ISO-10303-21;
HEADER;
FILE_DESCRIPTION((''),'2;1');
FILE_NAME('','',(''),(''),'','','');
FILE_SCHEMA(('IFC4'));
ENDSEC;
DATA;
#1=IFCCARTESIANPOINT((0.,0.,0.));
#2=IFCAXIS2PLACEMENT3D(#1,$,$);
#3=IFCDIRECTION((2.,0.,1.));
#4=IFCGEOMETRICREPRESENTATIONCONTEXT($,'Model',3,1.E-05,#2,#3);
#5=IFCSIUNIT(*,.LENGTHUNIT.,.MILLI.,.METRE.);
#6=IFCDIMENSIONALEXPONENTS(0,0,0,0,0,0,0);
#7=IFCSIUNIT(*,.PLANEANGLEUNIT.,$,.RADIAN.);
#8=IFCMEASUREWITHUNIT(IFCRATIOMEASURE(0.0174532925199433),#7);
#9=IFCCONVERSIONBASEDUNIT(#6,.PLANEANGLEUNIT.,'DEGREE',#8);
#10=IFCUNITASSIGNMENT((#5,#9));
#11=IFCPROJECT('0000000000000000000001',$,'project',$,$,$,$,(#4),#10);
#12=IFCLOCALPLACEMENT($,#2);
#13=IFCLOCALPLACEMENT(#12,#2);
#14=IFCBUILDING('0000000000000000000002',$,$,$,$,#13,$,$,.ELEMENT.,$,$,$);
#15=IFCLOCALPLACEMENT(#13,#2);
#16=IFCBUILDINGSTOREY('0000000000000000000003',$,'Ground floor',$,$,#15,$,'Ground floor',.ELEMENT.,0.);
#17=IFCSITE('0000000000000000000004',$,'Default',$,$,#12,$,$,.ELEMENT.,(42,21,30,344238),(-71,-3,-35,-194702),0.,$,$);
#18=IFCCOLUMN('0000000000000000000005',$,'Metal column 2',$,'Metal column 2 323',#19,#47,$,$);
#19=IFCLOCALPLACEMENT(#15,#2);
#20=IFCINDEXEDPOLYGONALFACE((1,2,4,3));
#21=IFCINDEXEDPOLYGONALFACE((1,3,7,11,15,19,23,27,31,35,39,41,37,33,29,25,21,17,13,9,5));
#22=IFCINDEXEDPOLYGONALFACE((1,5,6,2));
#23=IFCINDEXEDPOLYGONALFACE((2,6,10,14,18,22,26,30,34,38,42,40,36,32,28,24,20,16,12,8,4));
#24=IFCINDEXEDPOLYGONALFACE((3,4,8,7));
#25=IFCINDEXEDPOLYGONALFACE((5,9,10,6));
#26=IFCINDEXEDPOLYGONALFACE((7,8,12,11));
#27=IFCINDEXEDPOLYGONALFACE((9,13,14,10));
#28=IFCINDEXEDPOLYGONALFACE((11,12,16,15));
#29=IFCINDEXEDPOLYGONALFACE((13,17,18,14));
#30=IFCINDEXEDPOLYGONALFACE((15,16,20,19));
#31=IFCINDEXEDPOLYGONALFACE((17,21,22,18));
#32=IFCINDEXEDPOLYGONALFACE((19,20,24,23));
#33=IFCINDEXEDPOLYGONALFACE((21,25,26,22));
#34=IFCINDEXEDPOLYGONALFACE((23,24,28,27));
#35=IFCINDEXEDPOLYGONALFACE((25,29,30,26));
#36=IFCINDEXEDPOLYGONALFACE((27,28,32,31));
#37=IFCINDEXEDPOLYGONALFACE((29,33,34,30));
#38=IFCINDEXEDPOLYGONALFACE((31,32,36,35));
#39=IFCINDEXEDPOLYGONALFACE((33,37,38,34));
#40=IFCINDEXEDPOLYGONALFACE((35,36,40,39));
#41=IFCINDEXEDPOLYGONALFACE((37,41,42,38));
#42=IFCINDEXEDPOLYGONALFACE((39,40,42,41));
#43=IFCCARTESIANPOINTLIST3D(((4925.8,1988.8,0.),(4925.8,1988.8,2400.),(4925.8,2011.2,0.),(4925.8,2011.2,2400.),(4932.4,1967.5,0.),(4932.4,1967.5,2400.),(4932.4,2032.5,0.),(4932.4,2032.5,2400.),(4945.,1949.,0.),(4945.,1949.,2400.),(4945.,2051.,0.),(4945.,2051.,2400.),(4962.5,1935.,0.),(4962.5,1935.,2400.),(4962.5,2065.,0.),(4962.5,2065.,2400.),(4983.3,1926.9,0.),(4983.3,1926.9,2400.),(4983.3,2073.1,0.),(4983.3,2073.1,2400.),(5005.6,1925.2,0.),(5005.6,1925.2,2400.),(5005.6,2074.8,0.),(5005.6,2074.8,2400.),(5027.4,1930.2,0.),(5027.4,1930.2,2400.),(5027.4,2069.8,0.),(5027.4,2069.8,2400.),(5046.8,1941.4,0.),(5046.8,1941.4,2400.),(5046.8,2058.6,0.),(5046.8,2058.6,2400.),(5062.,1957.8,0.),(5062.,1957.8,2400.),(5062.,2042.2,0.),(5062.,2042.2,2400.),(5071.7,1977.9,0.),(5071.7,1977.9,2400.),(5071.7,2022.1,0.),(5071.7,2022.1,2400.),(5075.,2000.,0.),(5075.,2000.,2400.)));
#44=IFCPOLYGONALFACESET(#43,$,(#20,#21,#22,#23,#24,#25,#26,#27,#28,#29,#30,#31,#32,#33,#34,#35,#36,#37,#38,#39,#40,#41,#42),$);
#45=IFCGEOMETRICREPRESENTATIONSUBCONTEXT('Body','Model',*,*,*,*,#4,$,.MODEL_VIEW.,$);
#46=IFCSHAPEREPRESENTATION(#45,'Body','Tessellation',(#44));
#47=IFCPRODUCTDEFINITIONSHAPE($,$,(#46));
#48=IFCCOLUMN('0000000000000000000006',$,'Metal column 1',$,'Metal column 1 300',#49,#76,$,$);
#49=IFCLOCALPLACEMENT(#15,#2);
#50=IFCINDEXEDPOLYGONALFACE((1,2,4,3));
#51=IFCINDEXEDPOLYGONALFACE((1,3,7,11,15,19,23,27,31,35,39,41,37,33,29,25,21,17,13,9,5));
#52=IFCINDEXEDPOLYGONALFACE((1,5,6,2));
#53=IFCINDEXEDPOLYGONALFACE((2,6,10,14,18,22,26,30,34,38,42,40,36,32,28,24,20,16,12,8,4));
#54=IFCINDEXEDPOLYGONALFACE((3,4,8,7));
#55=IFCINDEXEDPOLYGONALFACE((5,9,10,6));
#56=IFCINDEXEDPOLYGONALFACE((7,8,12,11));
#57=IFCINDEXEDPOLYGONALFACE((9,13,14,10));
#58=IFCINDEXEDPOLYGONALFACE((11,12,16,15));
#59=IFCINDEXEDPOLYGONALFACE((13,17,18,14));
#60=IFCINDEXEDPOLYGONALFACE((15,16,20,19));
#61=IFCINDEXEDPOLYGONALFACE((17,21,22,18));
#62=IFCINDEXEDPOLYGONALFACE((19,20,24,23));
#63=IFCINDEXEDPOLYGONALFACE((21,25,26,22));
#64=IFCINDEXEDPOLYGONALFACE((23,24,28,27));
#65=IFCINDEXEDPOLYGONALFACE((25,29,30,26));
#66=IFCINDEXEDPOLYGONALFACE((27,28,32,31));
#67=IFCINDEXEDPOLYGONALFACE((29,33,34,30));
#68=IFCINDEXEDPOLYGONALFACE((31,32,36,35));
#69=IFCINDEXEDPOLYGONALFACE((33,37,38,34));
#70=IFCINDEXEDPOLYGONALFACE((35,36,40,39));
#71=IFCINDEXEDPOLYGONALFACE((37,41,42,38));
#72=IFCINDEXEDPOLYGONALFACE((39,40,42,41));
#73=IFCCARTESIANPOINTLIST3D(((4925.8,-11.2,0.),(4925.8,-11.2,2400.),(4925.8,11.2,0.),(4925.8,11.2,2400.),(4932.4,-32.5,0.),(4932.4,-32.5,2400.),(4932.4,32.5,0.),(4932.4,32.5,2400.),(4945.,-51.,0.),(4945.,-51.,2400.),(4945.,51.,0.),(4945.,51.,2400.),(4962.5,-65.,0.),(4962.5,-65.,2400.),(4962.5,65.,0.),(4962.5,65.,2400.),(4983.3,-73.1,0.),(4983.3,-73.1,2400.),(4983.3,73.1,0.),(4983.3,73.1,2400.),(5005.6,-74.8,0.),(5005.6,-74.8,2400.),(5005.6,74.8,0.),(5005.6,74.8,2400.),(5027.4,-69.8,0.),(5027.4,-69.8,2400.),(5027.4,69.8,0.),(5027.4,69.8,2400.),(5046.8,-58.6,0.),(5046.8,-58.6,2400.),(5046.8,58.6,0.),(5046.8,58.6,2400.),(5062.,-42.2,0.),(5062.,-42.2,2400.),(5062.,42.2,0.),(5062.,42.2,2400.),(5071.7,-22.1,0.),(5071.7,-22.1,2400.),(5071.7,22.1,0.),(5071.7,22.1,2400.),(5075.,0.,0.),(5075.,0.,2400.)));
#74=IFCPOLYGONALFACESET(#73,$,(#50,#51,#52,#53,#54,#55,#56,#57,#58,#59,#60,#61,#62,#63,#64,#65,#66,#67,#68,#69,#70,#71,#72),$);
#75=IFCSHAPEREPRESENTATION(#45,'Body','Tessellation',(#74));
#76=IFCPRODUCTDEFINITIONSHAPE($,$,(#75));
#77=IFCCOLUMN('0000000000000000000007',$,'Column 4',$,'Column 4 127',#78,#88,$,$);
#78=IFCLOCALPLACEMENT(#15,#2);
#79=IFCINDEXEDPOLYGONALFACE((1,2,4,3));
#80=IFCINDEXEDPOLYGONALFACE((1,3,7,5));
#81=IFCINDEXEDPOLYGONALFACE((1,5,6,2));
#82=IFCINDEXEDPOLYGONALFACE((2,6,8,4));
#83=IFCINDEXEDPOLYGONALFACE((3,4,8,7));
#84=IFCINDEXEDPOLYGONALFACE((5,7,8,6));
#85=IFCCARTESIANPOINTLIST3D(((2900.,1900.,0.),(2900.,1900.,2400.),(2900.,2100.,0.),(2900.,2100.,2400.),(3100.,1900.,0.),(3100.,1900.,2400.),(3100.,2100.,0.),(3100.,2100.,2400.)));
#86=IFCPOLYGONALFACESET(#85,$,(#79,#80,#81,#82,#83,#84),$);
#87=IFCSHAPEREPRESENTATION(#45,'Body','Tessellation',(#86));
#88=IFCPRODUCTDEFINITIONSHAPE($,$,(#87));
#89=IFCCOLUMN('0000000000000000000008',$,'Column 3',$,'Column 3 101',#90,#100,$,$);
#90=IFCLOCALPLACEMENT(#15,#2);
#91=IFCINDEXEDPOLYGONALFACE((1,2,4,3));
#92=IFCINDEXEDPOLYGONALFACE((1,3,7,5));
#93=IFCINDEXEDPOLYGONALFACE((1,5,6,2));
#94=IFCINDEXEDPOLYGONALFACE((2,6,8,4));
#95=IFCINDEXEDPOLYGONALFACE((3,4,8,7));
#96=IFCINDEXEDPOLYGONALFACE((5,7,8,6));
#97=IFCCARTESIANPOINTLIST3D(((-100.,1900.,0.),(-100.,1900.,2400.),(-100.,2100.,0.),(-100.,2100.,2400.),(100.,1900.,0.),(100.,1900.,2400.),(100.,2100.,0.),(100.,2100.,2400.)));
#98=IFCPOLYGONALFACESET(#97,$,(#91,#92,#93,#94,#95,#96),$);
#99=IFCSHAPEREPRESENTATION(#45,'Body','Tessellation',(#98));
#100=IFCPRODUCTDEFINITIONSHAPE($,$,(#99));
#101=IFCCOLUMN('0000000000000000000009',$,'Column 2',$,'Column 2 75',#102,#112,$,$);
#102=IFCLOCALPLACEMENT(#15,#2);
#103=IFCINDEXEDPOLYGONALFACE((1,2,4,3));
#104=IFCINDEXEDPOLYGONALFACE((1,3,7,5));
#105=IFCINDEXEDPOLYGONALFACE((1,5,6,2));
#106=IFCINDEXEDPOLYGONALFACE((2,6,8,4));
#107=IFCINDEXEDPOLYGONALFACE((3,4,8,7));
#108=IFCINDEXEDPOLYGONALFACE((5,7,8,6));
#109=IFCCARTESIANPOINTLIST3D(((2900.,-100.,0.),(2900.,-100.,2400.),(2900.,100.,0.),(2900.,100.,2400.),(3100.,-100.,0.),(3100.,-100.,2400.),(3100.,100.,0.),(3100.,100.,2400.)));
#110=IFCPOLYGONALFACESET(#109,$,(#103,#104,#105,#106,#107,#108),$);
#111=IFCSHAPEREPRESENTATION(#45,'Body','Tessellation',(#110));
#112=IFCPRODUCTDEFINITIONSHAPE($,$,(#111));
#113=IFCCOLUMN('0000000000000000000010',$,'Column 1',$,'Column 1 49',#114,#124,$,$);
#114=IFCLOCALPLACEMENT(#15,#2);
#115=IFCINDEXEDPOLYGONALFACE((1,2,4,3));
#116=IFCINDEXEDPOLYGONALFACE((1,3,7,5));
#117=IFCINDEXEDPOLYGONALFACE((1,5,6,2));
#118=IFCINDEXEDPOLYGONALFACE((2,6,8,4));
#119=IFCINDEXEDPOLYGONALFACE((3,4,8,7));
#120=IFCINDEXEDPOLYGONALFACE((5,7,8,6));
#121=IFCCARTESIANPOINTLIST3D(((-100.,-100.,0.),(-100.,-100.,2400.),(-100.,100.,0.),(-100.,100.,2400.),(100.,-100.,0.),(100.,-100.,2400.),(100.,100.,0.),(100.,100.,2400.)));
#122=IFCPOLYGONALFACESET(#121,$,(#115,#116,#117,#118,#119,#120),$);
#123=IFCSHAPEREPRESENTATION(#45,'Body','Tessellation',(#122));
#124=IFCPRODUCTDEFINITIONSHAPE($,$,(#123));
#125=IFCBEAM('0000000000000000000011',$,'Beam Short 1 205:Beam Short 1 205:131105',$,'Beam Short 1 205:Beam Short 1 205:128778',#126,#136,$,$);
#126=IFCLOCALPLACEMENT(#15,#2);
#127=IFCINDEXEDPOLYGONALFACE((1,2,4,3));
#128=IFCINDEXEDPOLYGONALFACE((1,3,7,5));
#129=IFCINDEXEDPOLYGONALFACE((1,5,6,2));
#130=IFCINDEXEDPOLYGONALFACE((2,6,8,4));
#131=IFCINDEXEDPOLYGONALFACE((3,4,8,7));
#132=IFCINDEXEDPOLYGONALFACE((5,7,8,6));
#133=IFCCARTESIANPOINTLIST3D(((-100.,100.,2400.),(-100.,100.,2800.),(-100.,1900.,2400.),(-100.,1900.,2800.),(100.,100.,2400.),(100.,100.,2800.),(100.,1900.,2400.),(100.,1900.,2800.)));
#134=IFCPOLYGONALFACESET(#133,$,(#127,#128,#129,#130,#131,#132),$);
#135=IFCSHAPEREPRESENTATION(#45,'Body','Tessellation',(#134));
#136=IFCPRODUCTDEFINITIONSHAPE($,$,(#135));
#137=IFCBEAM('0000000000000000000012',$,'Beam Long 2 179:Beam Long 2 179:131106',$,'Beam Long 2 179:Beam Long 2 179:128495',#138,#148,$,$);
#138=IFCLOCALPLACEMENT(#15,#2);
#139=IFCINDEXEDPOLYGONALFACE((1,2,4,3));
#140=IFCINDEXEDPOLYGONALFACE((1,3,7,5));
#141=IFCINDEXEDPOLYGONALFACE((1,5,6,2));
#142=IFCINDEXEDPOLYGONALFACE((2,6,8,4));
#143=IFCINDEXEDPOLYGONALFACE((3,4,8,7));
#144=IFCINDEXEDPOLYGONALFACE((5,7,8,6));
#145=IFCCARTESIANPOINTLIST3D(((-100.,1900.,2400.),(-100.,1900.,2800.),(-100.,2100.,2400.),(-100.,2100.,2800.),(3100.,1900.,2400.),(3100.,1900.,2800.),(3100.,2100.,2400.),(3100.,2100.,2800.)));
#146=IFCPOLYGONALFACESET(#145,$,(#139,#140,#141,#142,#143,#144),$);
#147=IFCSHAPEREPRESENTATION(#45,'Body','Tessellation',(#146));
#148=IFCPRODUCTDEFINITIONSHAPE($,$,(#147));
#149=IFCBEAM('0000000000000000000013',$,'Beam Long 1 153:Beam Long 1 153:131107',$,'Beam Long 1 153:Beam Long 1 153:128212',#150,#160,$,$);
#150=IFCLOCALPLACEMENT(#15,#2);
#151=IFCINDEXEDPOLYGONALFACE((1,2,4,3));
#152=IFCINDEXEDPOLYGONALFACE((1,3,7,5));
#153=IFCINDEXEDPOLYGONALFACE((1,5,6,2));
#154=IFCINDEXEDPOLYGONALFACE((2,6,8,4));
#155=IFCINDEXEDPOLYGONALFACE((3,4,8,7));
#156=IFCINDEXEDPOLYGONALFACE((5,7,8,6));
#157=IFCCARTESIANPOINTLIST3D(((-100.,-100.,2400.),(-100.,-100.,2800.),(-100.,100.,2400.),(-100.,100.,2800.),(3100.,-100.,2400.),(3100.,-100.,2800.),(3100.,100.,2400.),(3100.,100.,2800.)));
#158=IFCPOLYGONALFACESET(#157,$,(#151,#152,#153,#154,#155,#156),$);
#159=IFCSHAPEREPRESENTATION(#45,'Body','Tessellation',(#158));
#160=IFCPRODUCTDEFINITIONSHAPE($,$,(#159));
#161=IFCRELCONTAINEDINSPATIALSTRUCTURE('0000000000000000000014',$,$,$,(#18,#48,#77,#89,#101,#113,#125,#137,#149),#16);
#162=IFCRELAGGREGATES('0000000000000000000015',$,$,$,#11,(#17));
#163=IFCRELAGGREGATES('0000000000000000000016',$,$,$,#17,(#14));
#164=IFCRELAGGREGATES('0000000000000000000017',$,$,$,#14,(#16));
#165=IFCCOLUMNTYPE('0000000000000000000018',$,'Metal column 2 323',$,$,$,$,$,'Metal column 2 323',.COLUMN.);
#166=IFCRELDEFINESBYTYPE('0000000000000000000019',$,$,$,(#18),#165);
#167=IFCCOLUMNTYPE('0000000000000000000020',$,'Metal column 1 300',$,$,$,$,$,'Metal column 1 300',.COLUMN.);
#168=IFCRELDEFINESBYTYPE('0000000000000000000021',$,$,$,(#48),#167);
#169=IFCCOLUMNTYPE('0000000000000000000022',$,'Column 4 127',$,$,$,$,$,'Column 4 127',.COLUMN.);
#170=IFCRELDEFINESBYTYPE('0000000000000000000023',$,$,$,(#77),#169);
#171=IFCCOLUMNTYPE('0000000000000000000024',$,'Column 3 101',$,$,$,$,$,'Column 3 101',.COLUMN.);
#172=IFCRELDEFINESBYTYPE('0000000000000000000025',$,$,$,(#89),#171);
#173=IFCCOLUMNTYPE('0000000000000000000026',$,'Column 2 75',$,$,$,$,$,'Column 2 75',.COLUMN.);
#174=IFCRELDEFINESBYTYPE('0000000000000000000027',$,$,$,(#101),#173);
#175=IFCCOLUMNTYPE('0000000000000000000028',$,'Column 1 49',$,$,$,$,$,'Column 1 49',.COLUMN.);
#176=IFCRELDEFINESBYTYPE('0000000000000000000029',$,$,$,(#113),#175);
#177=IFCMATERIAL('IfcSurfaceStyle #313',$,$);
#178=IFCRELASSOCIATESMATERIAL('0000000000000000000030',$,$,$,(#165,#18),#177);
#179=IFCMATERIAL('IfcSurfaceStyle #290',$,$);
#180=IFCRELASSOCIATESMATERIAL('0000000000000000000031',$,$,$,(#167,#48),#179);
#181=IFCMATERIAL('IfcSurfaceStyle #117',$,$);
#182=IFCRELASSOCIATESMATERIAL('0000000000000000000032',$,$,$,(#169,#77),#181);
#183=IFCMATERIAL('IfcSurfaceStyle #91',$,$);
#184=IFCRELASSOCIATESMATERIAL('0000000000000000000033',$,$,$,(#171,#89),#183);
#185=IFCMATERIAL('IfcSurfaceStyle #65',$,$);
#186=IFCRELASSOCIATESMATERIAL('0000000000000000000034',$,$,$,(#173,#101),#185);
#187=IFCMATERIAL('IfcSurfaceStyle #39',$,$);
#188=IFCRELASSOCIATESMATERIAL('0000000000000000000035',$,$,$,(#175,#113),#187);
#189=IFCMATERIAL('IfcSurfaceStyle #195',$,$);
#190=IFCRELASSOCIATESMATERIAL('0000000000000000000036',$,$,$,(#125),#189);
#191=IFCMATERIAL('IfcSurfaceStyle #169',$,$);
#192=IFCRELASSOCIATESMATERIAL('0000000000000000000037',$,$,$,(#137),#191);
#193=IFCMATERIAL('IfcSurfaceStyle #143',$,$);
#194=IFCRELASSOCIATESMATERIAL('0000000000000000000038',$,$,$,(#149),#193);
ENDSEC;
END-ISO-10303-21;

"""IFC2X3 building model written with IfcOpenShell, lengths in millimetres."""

from ifc_helpers import new_model, entity, si_unit, converted_unit, direction, frame, frame_2d, origin, origin_2d_with_axis, place, context, subcontext, project, spatial, rectangle, circle, extrude, source, transform, mapped, material, type_object, type_shapes, element, save


model = new_model("IFC2X3")

# Units and contexts
model_context = context("Model", 3, precision=1e-05, world=origin(), true_north=direction((2.0, 0.0, 1.0)))
body_context = subcontext(model_context, "Body", "Model", "MODEL_VIEW")
ifc_project = project(units=[si_unit("LENGTHUNIT", "METRE", prefix="MILLI"), converted_unit("PLANEANGLEUNIT", "DEGREE", entity("IfcRatioMeasure", 0.0174532925199433), si_unit("PLANEANGLEUNIT", "RADIAN"), dimensions=[0, 0, 0, 0, 0, 0, 0])], contexts=[model_context])

# Site, building, storey
site_placement = place(None, origin())
site = spatial("IfcSite", under=ifc_project, at=site_placement, Name="Default", CompositionType="ELEMENT", RefLatitude=(42, 21, 30, 344238), RefLongitude=(-71, -3, -35, -194702), RefElevation=0.0)
building_placement = place(site_placement, origin())
building = spatial("IfcBuilding", under=site, at=building_placement, CompositionType="ELEMENT")
storey_placement = place(building_placement, origin())
storey = spatial("IfcBuildingStorey", under=building, at=storey_placement, Name="Ground floor", LongName="Ground floor", CompositionType="ELEMENT", Elevation=0.0)

# Columns
ifc_material_1 = material(Name="IfcSurfaceStyle #313")
column_type_1 = type_object("IfcColumnType", Name="Metal column 2 323", ElementType="Metal column 2 323", PredefinedType="COLUMN", material=ifc_material_1)
shared_shape_1 = source(origin(), body_context, "Body", "SweptSolid", [
    extrude(circle(Radius=75.0, at=frame_2d((0.0, 0.0), x_axis=(1.0, 0.0))), frame((5000.0, 2000.0, 0.0)), (0.0, 0.0, 1.0), 2400.0),
])
type_shapes(column_type_1, [shared_shape_1])
column_1_placement = place(building_placement, origin())
element("IfcColumn", 1, at=column_1_placement, inside=storey, type_object=column_type_1, material=ifc_material_1, Name="Metal column 2", ObjectType="Metal column 2 323", context=body_context, shape_type="MappedRepresentation", body=[
    mapped(shared_shape_1, transform((0.0, 0.0, 0.0), scale=1.0)),
])
ifc_material_2 = material(Name="IfcSurfaceStyle #290")
column_type_2 = type_object("IfcColumnType", Name="Metal column 1 300", ElementType="Metal column 1 300", PredefinedType="COLUMN", material=ifc_material_2)
shared_shape_2 = source(origin(), body_context, "Body", "SweptSolid", [
    extrude(circle(Radius=75.0, at=frame_2d((0.0, 0.0), x_axis=(1.0, 0.0))), frame((5000.0, 0.0, 0.0)), (0.0, 0.0, 1.0), 2400.0),
])
type_shapes(column_type_2, [shared_shape_2])
column_2_placement = place(building_placement, origin())
element("IfcColumn", 2, at=column_2_placement, inside=storey, type_object=column_type_2, material=ifc_material_2, Name="Metal column 1", ObjectType="Metal column 1 300", context=body_context, shape_type="MappedRepresentation", body=[
    mapped(shared_shape_2, transform((0.0, 0.0, 0.0), scale=1.0)),
])
ifc_material_3 = material(Name="IfcSurfaceStyle #117")
column_type_3 = type_object("IfcColumnType", Name="Column 4 127", ElementType="Column 4 127", PredefinedType="COLUMN", material=ifc_material_3)
shared_shape_3 = source(origin(), body_context, "Body", "SweptSolid", [
    extrude(rectangle(XDim=200.0, YDim=200.0, at=origin_2d_with_axis()), frame((3000.0, 2000.0, 0.0), z_axis=(0.0, 0.0, 1.0), x_axis=(0.0, -1.0, 0.0)), (0.0, 0.0, 1.0), 2400.0),
])
type_shapes(column_type_3, [shared_shape_3])
column_3_placement = place(building_placement, origin())
element("IfcColumn", 3, at=column_3_placement, inside=storey, type_object=column_type_3, material=ifc_material_3, Name="Column 4", ObjectType="Column 4 127", context=body_context, shape_type="MappedRepresentation", body=[
    mapped(shared_shape_3, transform((0.0, 0.0, 0.0), scale=1.0)),
])
ifc_material_4 = material(Name="IfcSurfaceStyle #91")
column_type_4 = type_object("IfcColumnType", Name="Column 3 101", ElementType="Column 3 101", PredefinedType="COLUMN", material=ifc_material_4)
shared_shape_4 = source(origin(), body_context, "Body", "SweptSolid", [
    extrude(rectangle(XDim=200.0, YDim=200.0, at=origin_2d_with_axis()), frame((0.0, 2000.0, 0.0), z_axis=(0.0, 0.0, 1.0), x_axis=(0.0, -1.0, 0.0)), (0.0, 0.0, 1.0), 2400.0),
])
type_shapes(column_type_4, [shared_shape_4])
column_4_placement = place(building_placement, origin())
element("IfcColumn", 4, at=column_4_placement, inside=storey, type_object=column_type_4, material=ifc_material_4, Name="Column 3", ObjectType="Column 3 101", context=body_context, shape_type="MappedRepresentation", body=[
    mapped(shared_shape_4, transform((0.0, 0.0, 0.0), scale=1.0)),
])
ifc_material_5 = material(Name="IfcSurfaceStyle #65")
column_type_5 = type_object("IfcColumnType", Name="Column 2 75", ElementType="Column 2 75", PredefinedType="COLUMN", material=ifc_material_5)
shared_shape_5 = source(origin(), body_context, "Body", "SweptSolid", [
    extrude(rectangle(XDim=200.0, YDim=200.0, at=origin_2d_with_axis()), frame((3000.0, 0.0, 0.0), z_axis=(0.0, 0.0, 1.0), x_axis=(0.0, -1.0, 0.0)), (0.0, 0.0, 1.0), 2400.0),
])
type_shapes(column_type_5, [shared_shape_5])
column_5_placement = place(building_placement, origin())
element("IfcColumn", 5, at=column_5_placement, inside=storey, type_object=column_type_5, material=ifc_material_5, Name="Column 2", ObjectType="Column 2 75", context=body_context, shape_type="MappedRepresentation", body=[
    mapped(shared_shape_5, transform((0.0, 0.0, 0.0), scale=1.0)),
])
ifc_material_6 = material(Name="IfcSurfaceStyle #39")
column_type_6 = type_object("IfcColumnType", Name="Column 1 49", ElementType="Column 1 49", PredefinedType="COLUMN", material=ifc_material_6)
shared_shape_6 = source(origin(), body_context, "Body", "SweptSolid", [
    extrude(rectangle(XDim=200.0, YDim=200.0, at=origin_2d_with_axis()), frame((0.0, 0.0, 0.0), z_axis=(0.0, 0.0, 1.0), x_axis=(0.0, -1.0, 0.0)), (0.0, 0.0, 1.0), 2400.0),
])
type_shapes(column_type_6, [shared_shape_6])
column_6_placement = place(building_placement, origin())
element("IfcColumn", 6, at=column_6_placement, inside=storey, type_object=column_type_6, material=ifc_material_6, Name="Column 1", ObjectType="Column 1 49", context=body_context, shape_type="MappedRepresentation", body=[
    mapped(shared_shape_6, transform((0.0, 0.0, 0.0), scale=1.0)),
])

# Beams
ifc_material_7 = material(Name="IfcSurfaceStyle #195")
beam_1_placement = place(storey_placement, frame((-100.0, 100.0, 2400.0)))
element("IfcBeam", 7, at=beam_1_placement, inside=storey, material=ifc_material_7, Name="Beam Short 1 205:Beam Short 1 205:131105", ObjectType="Beam Short 1 205:Beam Short 1 205:128778", context=body_context, shape_type="SweptSolid", body=[
    extrude(rectangle(XDim=400.0, YDim=1800.0, at=frame_2d((0.0, 0.0), x_axis=(0.0, 1.0))), frame((0.0, 900.0, 200.0), z_axis=(1.0, 0.0, 0.0), x_axis=(0.0, -1.0, 0.0)), (0.0, 0.0, 1.0), 200.0),
])
ifc_material_8 = material(Name="IfcSurfaceStyle #169")
beam_2_placement = place(storey_placement, frame((-100.0, 1900.0, 2400.0)))
element("IfcBeam", 8, at=beam_2_placement, inside=storey, material=ifc_material_8, Name="Beam Long 2 179:Beam Long 2 179:131106", ObjectType="Beam Long 2 179:Beam Long 2 179:128495", context=body_context, shape_type="SweptSolid", body=[
    extrude(rectangle(XDim=400.0, YDim=200.0, at=frame_2d((0.0, 0.0), x_axis=(0.0, 1.0))), frame((0.0, 100.0, 200.0), z_axis=(1.0, 0.0, 0.0), x_axis=(0.0, 1.0, 0.0)), (0.0, 0.0, 1.0), 3200.0),
])
ifc_material_9 = material(Name="IfcSurfaceStyle #143")
beam_3_placement = place(storey_placement, frame((-100.0, -100.0, 2400.0)))
element("IfcBeam", 9, at=beam_3_placement, inside=storey, material=ifc_material_9, Name="Beam Long 1 153:Beam Long 1 153:131107", ObjectType="Beam Long 1 153:Beam Long 1 153:128212", context=body_context, shape_type="SweptSolid", body=[
    extrude(rectangle(XDim=400.0, YDim=200.0, at=frame_2d((0.0, 0.0), x_axis=(0.0, 1.0))), frame((0.0, 100.0, 200.0), z_axis=(1.0, 0.0, 0.0), x_axis=(0.0, 1.0, 0.0)), (0.0, 0.0, 1.0), 3200.0),
])

save(model, "model.ifc")
